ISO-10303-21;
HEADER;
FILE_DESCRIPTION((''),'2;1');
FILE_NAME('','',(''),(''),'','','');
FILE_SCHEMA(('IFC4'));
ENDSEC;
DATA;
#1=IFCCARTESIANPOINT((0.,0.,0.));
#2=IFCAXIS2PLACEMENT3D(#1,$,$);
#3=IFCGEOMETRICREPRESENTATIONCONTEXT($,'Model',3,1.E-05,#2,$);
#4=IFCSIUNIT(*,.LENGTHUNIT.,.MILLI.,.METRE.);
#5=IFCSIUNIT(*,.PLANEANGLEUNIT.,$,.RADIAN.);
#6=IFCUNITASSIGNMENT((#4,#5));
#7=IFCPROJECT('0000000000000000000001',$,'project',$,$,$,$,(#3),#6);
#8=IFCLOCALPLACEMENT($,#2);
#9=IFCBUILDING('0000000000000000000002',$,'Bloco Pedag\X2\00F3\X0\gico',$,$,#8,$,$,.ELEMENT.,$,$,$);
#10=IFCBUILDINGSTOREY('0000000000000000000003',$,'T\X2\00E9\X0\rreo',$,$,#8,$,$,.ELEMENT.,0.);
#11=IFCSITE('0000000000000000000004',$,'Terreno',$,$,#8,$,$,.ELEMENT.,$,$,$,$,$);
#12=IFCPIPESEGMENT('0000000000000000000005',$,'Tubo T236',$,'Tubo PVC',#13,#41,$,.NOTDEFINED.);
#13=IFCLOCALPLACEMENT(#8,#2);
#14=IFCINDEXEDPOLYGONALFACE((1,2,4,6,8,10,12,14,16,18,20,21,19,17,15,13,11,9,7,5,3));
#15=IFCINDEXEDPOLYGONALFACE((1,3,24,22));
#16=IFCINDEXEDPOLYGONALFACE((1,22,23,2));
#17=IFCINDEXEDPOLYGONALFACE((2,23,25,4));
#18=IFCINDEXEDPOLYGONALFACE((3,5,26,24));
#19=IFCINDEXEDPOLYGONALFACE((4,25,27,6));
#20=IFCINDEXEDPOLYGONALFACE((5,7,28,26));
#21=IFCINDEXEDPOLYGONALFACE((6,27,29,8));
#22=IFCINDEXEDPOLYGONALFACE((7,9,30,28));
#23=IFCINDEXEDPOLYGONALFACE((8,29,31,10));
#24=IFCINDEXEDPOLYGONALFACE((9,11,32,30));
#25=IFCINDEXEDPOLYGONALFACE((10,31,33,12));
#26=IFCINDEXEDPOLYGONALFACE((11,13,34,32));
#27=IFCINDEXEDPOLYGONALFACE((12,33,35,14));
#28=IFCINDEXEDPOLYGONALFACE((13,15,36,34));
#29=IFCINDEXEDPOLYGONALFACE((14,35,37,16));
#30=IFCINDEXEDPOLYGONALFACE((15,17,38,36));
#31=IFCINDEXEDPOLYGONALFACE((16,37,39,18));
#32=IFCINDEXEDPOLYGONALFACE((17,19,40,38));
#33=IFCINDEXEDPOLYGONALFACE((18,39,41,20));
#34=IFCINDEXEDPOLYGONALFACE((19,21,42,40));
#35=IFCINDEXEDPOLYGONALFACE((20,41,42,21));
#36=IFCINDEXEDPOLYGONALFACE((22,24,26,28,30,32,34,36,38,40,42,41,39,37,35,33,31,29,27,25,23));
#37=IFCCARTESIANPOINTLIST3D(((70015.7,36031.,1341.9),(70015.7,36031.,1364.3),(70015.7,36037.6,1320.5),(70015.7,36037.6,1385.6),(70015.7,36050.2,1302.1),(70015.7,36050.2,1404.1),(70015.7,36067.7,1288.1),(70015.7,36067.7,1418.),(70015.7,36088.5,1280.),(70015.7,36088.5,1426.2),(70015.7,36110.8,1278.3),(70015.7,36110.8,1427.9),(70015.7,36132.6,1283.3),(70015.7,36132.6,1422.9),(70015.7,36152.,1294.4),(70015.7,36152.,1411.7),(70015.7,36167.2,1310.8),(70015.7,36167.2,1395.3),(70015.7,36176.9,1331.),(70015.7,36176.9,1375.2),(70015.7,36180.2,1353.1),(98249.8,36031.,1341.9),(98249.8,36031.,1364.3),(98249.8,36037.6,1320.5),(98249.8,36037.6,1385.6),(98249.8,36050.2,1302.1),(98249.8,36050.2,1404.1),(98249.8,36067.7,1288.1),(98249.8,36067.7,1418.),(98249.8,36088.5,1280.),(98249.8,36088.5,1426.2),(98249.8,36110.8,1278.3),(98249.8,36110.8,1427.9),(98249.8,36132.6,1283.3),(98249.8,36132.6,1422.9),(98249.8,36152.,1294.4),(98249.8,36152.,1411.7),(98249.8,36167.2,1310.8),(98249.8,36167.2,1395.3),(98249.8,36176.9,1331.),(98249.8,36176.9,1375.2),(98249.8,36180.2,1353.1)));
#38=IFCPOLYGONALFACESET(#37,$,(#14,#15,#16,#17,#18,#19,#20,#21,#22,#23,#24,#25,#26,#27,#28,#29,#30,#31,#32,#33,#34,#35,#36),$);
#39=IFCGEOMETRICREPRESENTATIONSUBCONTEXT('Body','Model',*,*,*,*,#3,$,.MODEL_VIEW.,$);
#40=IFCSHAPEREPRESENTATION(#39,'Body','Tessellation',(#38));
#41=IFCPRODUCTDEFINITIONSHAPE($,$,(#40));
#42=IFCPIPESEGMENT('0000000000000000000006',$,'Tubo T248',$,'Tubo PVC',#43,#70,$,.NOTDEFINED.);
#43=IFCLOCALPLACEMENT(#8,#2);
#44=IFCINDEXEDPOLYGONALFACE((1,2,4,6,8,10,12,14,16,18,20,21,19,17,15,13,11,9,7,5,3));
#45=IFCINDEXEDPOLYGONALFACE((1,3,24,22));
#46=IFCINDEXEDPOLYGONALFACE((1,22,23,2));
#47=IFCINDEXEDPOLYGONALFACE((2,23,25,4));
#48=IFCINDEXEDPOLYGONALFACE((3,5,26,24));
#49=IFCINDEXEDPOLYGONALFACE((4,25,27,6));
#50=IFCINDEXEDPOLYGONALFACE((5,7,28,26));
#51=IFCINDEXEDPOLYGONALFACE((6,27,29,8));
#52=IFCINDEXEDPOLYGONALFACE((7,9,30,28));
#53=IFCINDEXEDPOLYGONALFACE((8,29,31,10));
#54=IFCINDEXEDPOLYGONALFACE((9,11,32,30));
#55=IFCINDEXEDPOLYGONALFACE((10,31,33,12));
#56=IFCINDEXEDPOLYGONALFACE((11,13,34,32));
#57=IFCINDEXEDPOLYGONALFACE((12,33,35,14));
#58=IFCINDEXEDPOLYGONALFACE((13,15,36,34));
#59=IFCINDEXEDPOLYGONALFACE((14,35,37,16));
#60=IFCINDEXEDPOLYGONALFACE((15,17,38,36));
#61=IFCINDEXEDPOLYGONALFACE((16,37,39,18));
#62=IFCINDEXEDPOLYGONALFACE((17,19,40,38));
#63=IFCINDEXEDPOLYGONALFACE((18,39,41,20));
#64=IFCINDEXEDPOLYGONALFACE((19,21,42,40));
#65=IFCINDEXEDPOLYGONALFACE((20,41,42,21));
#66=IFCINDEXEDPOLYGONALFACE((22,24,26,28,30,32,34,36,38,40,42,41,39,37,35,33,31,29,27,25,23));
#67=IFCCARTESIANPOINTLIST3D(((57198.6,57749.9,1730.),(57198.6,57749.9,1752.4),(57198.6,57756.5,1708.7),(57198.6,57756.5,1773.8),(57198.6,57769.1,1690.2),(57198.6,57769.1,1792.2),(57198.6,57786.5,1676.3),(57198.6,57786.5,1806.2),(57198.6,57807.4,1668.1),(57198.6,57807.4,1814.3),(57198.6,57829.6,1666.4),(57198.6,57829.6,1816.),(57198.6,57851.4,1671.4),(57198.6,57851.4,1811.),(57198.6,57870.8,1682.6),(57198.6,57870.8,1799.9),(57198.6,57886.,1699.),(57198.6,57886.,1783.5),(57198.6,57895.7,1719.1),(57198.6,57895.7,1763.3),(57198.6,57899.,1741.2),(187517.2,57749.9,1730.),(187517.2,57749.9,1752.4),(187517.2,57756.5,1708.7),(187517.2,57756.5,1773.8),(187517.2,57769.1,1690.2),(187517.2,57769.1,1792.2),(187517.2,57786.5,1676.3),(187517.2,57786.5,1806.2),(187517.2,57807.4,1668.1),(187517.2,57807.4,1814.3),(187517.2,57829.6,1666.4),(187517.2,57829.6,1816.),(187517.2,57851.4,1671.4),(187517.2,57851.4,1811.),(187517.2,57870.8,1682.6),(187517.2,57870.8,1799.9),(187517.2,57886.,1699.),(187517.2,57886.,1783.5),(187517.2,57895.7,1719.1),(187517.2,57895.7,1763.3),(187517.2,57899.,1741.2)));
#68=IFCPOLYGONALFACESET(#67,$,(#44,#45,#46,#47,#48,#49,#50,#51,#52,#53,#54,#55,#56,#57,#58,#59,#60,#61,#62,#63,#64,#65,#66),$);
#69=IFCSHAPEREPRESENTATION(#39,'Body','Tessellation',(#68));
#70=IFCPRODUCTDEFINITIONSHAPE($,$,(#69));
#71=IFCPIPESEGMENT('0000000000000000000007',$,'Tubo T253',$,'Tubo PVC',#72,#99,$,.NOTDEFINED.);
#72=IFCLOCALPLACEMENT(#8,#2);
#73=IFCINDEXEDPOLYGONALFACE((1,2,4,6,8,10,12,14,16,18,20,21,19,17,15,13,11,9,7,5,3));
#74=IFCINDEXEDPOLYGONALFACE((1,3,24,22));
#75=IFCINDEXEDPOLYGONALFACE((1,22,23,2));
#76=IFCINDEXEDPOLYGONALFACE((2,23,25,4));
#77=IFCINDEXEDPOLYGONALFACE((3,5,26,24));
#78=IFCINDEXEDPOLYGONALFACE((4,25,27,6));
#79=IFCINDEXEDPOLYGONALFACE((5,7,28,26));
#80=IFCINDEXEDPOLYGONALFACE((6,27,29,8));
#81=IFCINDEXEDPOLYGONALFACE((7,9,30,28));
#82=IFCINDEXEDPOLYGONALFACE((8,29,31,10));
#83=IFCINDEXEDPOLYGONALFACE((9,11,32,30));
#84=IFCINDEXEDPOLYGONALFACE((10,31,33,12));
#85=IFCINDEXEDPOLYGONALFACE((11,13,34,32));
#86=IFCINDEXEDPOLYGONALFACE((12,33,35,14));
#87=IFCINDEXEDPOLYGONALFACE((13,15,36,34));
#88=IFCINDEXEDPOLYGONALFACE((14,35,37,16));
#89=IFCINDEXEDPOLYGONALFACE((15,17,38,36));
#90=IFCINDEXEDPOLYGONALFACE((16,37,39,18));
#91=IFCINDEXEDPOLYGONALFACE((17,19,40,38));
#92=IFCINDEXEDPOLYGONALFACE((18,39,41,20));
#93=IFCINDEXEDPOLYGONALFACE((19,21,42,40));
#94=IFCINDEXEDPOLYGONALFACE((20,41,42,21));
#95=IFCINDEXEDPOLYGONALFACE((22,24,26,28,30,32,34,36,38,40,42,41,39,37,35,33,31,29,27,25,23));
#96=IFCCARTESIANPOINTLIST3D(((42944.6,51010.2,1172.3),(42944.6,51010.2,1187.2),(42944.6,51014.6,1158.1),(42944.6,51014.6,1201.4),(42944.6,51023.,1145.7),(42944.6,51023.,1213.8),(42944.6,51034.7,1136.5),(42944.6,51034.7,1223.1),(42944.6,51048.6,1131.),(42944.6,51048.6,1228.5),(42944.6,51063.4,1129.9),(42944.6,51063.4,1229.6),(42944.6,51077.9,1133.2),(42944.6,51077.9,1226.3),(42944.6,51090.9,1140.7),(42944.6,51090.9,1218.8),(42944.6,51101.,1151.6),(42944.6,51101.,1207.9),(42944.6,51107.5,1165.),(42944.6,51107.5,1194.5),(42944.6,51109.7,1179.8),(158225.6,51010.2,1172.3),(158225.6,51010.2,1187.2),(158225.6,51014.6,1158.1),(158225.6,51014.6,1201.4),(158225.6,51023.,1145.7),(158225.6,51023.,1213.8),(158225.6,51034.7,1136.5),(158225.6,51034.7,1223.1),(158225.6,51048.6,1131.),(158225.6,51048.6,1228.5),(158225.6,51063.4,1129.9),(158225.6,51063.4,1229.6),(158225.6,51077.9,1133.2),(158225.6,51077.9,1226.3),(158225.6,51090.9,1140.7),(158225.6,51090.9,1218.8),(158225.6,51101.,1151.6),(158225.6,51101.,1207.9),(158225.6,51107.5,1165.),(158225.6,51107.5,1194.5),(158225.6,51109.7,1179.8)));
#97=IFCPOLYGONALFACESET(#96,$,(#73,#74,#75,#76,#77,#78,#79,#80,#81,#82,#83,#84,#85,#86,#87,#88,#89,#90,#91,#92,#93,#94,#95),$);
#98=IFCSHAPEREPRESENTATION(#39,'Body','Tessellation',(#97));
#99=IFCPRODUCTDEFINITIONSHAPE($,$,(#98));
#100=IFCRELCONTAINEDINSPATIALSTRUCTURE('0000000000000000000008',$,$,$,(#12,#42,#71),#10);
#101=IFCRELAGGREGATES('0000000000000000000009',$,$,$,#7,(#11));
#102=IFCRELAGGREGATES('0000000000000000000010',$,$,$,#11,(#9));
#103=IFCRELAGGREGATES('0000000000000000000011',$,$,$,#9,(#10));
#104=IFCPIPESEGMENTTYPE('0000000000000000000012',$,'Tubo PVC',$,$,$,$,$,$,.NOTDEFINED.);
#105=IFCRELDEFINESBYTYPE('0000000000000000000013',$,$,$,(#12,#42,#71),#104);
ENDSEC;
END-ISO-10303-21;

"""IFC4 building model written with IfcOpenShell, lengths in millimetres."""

from ifc_helpers import new_model, si_unit, frame, origin, origin_2d, place, context, subcontext, project, spatial, circle, extrude, type_object, element, save


model = new_model("IFC4")

# Units and contexts
model_context = context("Model", 3, precision=1e-05, world=origin())
body_context = subcontext(model_context, "Body", "Model", "MODEL_VIEW")
ifc_project = project(units=[si_unit("LENGTHUNIT", "METRE", prefix="MILLI"), si_unit("PLANEANGLEUNIT", "RADIAN")], contexts=[model_context])

# Site, building, storey
placement = place(None, origin())
site = spatial("IfcSite", under=ifc_project, at=placement, Name="Terreno", CompositionType="ELEMENT")
building = spatial("IfcBuilding", under=site, at=placement, Name="Bloco Pedagógico", CompositionType="ELEMENT")
storey = spatial("IfcBuildingStorey", under=building, at=placement, Name="Térreo", CompositionType="ELEMENT", Elevation=0.0)

# Pipe segments
pipe_segment_type = type_object("IfcPipeSegmentType", Name="Tubo PVC", PredefinedType="NOTDEFINED")
pipe_segment_1_placement = place(None, frame((70015.7, 36105.2, 1353.1), z_axis=(1.0, 0.0, 0.0), x_axis=(0.0, 1.0, 0.0)))
element("IfcPipeSegment", 1, at=pipe_segment_1_placement, inside=storey, type_object=pipe_segment_type, Name="Tubo T236", ObjectType="Tubo PVC", PredefinedType="NOTDEFINED", context=body_context, shape_type="SweptSolid", body=[
    extrude(circle(Radius=75.0, at=origin_2d()), None, (0.0, 0.0, 1.0), 28234.1),
])
pipe_segment_2_placement = place(None, frame((57198.6, 57824.0, 1741.2), z_axis=(1.0, 0.0, 0.0), x_axis=(0.0, 1.0, 0.0)))
element("IfcPipeSegment", 2, at=pipe_segment_2_placement, inside=storey, type_object=pipe_segment_type, Name="Tubo T248", ObjectType="Tubo PVC", PredefinedType="NOTDEFINED", context=body_context, shape_type="SweptSolid", body=[
    extrude(circle(Radius=75.0, at=origin_2d()), None, (0.0, 0.0, 1.0), 130318.6),
])
pipe_segment_3_placement = place(None, frame((42944.6, 51059.7, 1179.8), z_axis=(1.0, 0.0, 0.0), x_axis=(0.0, 1.0, 0.0)))
element("IfcPipeSegment", 3, at=pipe_segment_3_placement, inside=storey, type_object=pipe_segment_type, Name="Tubo T253", ObjectType="Tubo PVC", PredefinedType="NOTDEFINED", context=body_context, shape_type="SweptSolid", body=[
    extrude(circle(Radius=50.0, at=origin_2d()), None, (0.0, 0.0, 1.0), 115281.0),
])

save(model, "model.ifc")
